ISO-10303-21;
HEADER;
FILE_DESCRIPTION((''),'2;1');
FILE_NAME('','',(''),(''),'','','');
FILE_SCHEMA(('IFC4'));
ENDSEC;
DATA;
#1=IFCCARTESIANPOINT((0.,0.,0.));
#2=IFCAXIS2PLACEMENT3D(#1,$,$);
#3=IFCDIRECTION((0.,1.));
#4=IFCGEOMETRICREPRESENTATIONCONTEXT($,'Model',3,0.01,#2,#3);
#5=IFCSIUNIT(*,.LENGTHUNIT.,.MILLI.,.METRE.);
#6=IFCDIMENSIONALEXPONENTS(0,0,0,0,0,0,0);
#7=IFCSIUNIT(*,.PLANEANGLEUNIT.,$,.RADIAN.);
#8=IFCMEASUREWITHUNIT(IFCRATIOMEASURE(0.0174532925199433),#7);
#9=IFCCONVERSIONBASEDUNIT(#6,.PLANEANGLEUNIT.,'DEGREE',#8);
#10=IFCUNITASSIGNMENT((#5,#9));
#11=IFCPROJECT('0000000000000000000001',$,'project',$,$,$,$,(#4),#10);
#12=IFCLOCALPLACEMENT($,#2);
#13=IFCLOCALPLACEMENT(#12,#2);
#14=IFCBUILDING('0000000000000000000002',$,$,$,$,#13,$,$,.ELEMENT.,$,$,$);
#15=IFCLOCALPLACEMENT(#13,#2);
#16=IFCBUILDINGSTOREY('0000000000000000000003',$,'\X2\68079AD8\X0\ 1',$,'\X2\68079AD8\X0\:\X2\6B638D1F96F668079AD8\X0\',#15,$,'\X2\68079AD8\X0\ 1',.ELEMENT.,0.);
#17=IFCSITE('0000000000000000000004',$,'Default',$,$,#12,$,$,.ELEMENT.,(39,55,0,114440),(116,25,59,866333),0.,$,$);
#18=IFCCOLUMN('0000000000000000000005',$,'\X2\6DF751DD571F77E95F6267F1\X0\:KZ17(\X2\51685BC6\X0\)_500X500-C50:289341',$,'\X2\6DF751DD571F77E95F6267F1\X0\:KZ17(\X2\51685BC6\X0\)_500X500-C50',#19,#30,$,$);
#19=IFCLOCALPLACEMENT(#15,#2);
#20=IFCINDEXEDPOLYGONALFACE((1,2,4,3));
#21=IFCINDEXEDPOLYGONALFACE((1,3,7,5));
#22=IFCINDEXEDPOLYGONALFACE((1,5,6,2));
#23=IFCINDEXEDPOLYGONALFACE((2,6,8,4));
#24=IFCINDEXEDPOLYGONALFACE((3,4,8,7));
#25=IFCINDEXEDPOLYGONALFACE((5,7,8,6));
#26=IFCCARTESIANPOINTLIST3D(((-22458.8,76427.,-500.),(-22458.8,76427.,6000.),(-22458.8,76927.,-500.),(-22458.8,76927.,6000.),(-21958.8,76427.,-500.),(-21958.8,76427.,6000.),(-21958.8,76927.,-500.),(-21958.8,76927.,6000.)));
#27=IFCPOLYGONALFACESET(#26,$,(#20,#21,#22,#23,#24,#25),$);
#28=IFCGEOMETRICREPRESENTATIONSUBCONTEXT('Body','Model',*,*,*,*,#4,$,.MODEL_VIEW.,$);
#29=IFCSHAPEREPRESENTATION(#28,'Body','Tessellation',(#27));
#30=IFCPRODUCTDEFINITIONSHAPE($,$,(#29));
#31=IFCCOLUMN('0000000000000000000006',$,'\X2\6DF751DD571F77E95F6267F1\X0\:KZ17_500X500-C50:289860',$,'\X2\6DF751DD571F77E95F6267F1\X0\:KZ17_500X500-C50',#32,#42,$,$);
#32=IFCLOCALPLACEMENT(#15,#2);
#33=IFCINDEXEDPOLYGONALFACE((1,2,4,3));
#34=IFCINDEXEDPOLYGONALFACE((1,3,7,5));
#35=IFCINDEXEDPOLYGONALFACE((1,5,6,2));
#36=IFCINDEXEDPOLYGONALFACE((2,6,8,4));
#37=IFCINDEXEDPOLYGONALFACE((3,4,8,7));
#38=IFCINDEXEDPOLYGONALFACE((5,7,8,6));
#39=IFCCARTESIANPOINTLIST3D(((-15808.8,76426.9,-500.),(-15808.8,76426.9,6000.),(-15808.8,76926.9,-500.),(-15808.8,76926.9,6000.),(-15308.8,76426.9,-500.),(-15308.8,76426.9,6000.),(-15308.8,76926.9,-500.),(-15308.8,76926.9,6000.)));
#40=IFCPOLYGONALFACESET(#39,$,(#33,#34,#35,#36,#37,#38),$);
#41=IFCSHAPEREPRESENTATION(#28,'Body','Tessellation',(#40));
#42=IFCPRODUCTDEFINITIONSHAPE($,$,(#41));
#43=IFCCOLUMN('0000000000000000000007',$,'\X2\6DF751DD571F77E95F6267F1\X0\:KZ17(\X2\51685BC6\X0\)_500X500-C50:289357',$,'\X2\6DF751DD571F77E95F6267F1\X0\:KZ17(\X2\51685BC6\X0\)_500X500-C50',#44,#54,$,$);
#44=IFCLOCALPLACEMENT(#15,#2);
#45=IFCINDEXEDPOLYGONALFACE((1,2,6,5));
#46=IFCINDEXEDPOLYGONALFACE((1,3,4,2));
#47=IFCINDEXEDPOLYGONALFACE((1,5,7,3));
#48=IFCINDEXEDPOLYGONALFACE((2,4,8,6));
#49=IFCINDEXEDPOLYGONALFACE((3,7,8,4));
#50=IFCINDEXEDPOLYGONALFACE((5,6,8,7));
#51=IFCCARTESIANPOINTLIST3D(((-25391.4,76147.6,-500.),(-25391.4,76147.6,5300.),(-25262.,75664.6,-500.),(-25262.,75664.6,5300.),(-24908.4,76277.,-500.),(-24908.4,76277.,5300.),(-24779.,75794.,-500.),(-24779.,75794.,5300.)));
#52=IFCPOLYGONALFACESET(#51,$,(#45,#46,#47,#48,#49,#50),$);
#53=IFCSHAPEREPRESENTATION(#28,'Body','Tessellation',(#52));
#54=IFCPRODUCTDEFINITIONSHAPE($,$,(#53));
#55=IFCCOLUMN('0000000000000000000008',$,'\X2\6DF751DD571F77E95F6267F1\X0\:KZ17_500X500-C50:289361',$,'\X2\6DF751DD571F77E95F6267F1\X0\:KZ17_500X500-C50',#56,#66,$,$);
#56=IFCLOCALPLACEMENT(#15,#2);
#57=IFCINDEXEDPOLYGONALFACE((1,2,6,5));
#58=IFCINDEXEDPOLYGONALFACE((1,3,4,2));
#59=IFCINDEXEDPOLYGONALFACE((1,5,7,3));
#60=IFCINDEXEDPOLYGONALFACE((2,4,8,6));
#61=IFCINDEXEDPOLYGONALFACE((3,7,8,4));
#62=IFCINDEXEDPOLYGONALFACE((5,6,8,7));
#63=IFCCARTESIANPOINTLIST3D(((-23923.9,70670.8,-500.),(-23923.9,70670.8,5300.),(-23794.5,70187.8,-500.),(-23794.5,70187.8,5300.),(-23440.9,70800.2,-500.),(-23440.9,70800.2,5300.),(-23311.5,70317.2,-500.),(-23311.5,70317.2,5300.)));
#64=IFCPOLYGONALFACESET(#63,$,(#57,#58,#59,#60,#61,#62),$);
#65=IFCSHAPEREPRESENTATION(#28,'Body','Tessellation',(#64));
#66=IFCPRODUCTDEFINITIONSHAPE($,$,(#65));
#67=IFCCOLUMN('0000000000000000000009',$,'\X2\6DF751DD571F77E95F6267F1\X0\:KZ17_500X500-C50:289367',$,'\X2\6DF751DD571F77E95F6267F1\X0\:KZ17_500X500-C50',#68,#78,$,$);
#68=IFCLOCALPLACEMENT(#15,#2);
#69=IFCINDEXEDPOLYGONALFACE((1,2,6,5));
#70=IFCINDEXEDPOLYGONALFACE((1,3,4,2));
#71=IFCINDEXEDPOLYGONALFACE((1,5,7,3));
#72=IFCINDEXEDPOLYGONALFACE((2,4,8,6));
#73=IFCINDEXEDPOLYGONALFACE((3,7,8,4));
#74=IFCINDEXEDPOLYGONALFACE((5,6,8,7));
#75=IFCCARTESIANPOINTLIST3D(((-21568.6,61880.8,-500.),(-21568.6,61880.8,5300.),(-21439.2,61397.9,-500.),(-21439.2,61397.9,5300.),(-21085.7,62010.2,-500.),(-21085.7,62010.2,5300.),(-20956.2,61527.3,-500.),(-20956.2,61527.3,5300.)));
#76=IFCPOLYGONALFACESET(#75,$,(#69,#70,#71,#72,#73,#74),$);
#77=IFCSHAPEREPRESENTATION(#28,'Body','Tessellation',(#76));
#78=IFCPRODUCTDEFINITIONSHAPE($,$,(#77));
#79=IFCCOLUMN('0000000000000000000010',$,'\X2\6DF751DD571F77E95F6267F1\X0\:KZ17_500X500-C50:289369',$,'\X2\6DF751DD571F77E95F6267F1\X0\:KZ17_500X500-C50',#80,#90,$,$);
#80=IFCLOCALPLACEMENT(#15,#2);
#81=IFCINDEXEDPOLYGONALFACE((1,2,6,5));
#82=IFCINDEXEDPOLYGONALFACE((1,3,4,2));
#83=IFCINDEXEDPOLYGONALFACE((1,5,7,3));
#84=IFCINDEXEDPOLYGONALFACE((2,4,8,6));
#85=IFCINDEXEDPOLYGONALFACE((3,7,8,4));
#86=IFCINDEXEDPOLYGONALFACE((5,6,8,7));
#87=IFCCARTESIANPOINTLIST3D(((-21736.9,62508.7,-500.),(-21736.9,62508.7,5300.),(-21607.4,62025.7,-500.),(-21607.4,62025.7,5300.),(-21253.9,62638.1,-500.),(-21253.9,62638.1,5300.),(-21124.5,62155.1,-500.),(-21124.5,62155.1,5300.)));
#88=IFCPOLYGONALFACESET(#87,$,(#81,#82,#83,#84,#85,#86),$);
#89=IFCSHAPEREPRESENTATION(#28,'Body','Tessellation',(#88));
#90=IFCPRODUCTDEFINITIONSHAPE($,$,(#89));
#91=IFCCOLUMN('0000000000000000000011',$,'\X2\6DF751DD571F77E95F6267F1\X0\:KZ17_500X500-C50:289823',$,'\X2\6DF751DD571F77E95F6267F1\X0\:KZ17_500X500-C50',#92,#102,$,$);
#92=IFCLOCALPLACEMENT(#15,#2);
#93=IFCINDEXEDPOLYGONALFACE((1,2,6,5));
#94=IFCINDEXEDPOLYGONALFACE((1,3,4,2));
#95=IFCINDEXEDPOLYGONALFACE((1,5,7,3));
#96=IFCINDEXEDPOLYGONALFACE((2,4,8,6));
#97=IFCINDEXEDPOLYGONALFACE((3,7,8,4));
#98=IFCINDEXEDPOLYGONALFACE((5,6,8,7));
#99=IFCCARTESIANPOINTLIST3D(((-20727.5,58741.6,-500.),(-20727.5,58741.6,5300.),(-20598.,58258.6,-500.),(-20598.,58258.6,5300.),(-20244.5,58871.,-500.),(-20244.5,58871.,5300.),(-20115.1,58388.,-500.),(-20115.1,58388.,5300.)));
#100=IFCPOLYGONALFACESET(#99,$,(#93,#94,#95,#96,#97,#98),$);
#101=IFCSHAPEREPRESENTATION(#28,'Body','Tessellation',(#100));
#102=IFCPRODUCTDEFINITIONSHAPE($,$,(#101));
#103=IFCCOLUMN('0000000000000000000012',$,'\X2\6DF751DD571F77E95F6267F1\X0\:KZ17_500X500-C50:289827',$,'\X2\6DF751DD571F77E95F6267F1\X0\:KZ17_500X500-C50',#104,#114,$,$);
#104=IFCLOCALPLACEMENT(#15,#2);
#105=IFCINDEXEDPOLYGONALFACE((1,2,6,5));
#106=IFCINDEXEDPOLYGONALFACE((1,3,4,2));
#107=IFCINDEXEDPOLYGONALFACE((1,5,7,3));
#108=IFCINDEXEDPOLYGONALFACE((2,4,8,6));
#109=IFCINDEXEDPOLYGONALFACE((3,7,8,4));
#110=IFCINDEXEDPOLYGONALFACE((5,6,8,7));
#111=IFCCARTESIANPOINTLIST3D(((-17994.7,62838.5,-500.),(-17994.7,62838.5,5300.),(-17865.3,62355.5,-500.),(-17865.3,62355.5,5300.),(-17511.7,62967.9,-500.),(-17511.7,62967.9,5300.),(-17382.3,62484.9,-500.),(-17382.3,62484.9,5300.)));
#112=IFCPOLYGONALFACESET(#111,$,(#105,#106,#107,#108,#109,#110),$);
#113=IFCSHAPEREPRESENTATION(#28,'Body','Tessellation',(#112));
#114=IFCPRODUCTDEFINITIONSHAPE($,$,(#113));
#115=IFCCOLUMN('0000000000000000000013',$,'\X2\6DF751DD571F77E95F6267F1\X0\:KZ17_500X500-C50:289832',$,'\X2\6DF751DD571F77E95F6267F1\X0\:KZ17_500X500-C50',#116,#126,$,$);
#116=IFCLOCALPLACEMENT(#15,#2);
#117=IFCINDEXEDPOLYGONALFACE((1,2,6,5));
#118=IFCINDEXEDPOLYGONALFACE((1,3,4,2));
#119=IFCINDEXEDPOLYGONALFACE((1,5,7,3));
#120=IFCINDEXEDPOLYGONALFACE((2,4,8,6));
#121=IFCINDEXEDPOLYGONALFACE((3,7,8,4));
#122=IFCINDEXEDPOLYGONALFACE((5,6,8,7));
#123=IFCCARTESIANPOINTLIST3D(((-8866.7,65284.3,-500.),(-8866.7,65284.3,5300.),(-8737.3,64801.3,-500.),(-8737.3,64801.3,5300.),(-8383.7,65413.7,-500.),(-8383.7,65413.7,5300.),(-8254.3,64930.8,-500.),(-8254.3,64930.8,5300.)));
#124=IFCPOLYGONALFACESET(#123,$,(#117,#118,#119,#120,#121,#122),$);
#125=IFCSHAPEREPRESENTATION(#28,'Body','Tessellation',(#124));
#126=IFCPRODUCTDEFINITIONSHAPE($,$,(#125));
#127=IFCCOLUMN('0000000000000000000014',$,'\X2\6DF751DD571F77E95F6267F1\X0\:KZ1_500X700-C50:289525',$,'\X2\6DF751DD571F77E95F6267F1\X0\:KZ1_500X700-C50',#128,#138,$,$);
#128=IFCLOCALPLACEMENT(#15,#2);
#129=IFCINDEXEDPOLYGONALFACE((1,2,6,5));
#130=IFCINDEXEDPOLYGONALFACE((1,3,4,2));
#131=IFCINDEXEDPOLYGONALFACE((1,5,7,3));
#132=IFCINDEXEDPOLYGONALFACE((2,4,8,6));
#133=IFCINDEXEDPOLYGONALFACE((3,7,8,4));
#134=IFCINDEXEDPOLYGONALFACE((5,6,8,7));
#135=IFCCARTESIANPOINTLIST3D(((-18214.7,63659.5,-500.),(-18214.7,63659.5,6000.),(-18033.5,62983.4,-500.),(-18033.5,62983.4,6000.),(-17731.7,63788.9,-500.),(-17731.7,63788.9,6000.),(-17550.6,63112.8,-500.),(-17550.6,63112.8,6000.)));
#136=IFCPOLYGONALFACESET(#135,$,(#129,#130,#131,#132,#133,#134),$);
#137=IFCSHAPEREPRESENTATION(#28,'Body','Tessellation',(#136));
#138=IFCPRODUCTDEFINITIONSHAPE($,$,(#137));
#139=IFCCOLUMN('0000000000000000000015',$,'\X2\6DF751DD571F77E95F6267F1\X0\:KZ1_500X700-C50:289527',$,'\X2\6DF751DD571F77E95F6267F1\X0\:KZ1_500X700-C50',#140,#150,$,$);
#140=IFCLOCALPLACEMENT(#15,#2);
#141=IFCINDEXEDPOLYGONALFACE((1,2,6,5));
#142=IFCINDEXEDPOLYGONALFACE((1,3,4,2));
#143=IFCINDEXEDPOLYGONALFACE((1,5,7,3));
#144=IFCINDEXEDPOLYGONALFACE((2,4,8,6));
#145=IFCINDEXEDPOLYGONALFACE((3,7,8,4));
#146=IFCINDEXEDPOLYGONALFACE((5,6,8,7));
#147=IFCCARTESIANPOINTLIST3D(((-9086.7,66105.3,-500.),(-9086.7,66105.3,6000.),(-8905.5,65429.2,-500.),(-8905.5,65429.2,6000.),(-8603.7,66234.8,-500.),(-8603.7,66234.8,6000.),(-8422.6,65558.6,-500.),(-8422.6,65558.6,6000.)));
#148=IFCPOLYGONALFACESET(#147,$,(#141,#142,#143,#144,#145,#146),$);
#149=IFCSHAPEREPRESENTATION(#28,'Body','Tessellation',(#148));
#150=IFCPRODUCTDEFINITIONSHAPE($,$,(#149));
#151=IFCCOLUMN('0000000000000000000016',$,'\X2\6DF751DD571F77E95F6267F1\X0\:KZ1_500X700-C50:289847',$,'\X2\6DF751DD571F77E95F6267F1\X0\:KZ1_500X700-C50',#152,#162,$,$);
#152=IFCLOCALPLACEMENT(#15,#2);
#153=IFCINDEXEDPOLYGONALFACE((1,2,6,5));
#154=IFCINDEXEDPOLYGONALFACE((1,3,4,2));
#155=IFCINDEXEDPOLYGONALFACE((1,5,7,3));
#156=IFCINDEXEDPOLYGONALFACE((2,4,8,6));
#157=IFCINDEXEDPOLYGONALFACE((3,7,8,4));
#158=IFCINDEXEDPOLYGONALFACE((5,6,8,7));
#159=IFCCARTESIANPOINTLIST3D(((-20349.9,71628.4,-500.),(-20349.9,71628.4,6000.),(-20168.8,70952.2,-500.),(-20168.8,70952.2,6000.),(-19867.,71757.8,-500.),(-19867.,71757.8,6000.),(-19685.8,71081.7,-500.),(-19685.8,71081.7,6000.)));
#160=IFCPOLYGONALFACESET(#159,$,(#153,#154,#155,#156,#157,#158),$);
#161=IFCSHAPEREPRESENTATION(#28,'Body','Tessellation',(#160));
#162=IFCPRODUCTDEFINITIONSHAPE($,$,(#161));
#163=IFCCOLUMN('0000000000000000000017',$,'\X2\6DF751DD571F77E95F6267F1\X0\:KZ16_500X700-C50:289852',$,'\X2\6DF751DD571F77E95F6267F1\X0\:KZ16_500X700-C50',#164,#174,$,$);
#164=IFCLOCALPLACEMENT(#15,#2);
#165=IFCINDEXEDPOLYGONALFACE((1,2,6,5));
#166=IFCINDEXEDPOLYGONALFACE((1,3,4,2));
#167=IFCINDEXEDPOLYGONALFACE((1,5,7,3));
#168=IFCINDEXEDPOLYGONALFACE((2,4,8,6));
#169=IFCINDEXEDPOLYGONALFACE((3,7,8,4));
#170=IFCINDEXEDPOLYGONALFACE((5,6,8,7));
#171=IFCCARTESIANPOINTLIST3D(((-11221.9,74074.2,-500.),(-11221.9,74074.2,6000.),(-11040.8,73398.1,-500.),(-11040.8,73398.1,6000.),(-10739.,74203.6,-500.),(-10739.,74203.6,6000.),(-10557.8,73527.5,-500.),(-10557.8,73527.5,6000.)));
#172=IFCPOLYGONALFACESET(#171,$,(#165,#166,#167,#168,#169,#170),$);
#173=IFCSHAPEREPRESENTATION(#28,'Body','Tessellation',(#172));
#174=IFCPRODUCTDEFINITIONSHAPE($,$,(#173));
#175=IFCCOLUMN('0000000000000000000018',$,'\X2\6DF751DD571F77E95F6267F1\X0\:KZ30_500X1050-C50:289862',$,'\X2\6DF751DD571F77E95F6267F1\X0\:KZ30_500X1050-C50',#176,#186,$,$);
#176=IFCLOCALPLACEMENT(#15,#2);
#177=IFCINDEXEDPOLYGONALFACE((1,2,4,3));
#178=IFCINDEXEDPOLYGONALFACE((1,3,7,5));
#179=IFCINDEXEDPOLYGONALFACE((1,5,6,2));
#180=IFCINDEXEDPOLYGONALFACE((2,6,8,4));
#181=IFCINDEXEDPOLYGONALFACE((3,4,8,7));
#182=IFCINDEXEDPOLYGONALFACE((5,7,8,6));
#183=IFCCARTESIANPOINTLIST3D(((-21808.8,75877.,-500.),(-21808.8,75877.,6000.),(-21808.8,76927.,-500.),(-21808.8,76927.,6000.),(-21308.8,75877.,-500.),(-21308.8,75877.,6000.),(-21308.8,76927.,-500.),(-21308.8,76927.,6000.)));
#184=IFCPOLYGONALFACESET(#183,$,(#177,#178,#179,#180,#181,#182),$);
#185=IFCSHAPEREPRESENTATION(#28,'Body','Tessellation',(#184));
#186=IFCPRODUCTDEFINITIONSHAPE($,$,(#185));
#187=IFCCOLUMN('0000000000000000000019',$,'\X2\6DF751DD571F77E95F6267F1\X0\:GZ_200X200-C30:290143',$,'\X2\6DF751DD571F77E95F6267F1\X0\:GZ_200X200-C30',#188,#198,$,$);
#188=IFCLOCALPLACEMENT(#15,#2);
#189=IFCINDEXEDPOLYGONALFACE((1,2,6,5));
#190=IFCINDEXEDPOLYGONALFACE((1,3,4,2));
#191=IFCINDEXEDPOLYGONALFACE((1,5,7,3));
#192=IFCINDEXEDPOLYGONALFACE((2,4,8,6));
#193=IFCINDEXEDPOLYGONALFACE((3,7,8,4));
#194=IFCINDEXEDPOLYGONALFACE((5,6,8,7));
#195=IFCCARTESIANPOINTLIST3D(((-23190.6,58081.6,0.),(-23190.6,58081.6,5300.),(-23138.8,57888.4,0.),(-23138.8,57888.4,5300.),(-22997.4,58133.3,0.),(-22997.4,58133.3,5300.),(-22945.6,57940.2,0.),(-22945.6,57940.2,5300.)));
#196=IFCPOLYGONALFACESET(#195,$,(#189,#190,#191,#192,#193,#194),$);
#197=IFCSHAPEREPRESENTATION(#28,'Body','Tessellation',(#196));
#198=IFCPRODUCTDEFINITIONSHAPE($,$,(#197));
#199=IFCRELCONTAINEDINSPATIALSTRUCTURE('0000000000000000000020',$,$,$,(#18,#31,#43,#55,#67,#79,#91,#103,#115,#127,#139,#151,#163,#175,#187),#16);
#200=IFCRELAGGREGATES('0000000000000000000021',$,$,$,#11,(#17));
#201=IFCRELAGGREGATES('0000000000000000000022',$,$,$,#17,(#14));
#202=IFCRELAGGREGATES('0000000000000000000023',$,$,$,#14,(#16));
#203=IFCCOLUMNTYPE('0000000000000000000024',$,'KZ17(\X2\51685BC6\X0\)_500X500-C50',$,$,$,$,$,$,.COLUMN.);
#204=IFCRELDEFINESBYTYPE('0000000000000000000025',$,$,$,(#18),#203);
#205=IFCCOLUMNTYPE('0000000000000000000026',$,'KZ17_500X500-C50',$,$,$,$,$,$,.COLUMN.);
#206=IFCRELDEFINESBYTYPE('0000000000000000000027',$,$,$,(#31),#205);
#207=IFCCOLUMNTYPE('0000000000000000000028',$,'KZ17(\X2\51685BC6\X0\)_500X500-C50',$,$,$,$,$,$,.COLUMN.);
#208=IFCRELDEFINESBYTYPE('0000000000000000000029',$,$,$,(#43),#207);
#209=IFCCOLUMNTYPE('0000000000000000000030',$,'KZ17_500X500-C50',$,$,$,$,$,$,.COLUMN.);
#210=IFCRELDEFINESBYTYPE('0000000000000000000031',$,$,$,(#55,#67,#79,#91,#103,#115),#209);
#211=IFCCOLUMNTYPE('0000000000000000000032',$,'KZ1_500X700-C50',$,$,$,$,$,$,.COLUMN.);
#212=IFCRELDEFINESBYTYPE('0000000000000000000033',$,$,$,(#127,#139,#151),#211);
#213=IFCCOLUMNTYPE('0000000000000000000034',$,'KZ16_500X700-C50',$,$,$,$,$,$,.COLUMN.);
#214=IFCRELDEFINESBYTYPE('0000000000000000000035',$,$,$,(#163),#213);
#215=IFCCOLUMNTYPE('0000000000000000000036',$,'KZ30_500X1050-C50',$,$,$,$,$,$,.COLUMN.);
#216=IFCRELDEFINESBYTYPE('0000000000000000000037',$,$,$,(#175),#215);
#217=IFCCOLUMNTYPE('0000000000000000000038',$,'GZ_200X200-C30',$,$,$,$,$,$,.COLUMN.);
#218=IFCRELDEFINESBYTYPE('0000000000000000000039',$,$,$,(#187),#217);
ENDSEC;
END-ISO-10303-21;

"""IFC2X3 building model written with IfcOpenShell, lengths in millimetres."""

from ifc_helpers import new_model, entity, si_unit, converted_unit, direction, frame, origin, origin_2d_with_axis, place, context, subcontext, project, spatial, rectangle, extrude, source, transform, mapped, type_object, type_shapes, element, save


model = new_model("IFC2X3")

# Units and contexts
model_context = context("Model", 3, precision=0.01, world=origin(), true_north=direction((0.0, 1.0)))
body_context = subcontext(model_context, "Body", "Model", "MODEL_VIEW")
ifc_project = project(units=[si_unit("LENGTHUNIT", "METRE", prefix="MILLI"), converted_unit("PLANEANGLEUNIT", "DEGREE", entity("IfcRatioMeasure", 0.0174532925199433), si_unit("PLANEANGLEUNIT", "RADIAN"), dimensions=[0, 0, 0, 0, 0, 0, 0])], contexts=[model_context])

# Site, building, storey
site_placement = place(None, origin())
site = spatial("IfcSite", under=ifc_project, at=site_placement, Name="Default", CompositionType="ELEMENT", RefLatitude=(39, 55, 0, 114440), RefLongitude=(116, 25, 59, 866333), RefElevation=0.0)
building_placement = place(site_placement, origin())
building = spatial("IfcBuilding", under=site, at=building_placement, CompositionType="ELEMENT")
storey_placement = place(building_placement, origin())
storey = spatial("IfcBuildingStorey", under=building, at=storey_placement, Name="标高 1", ObjectType="标高:正负零标高", LongName="标高 1", CompositionType="ELEMENT", Elevation=0.0)

# Columns
column_type_1 = type_object("IfcColumnType", Name="KZ17(全密)_500X500-C50", PredefinedType="COLUMN")
shared_shape_1 = source(origin(), body_context, "Body", "SweptSolid", [
    extrude(rectangle(XDim=500.0, YDim=500.0, at=origin_2d_with_axis()), frame((0.0, 0.0, -500.0), z_axis=(0.0, 0.0, 1.0), x_axis=(0.0, -1.0, 0.0)), (0.0, 0.0, 1.0), 6500.0),
])
type_shapes(column_type_1, [shared_shape_1])
column_1_placement = place(building_placement, frame((-22208.8, 76677.0, 0.0)))
element("IfcColumn", 1, at=column_1_placement, inside=storey, type_object=column_type_1, Name="混凝土矩形柱:KZ17(全密)_500X500-C50:289341", ObjectType="混凝土矩形柱:KZ17(全密)_500X500-C50", context=body_context, shape_type="MappedRepresentation", body=[
    mapped(shared_shape_1, transform((0.0, 0.0, 0.0), scale=1.0)),
])
column_type_2 = type_object("IfcColumnType", Name="KZ17_500X500-C50", PredefinedType="COLUMN")
shared_shape_2 = source(origin(), body_context, "Body", "SweptSolid", [
    extrude(rectangle(XDim=500.0, YDim=500.0, at=origin_2d_with_axis()), frame((0.0, 0.0, -500.0), z_axis=(0.0, 0.0, 1.0), x_axis=(0.0, -1.0, 0.0)), (0.0, 0.0, 1.0), 6500.0),
])
type_shapes(column_type_2, [shared_shape_2])
column_2_placement = place(building_placement, frame((-15558.8, 76676.9, 0.0)))
element("IfcColumn", 2, at=column_2_placement, inside=storey, type_object=column_type_2, Name="混凝土矩形柱:KZ17_500X500-C50:289860", ObjectType="混凝土矩形柱:KZ17_500X500-C50", context=body_context, shape_type="MappedRepresentation", body=[
    mapped(shared_shape_2, transform((0.0, 0.0, 0.0), scale=1.0)),
])
column_type_3 = type_object("IfcColumnType", Name="KZ17(全密)_500X500-C50", PredefinedType="COLUMN")
shared_shape_3 = source(origin(), body_context, "Body", "SweptSolid", [
    extrude(rectangle(XDim=500.0, YDim=500.0, at=origin_2d_with_axis()), frame((0.0, 0.0, -500.0), z_axis=(0.0, 0.0, 1.0), x_axis=(0.0, -1.0, 0.0)), (0.0, 0.0, 1.0), 5800.0),
])
type_shapes(column_type_3, [shared_shape_3])
column_3_placement = place(building_placement, frame((-25085.2, 75970.8, 0.0), z_axis=(0.0, 0.0, 1.0), x_axis=(0.258819, -0.965926, 0.0)))
element("IfcColumn", 3, at=column_3_placement, inside=storey, type_object=column_type_3, Name="混凝土矩形柱:KZ17(全密)_500X500-C50:289357", ObjectType="混凝土矩形柱:KZ17(全密)_500X500-C50", context=body_context, shape_type="MappedRepresentation", body=[
    mapped(shared_shape_3, transform((0.0, 0.0, 0.0), scale=1.0)),
])
column_type_4 = type_object("IfcColumnType", Name="KZ17_500X500-C50", PredefinedType="COLUMN")
shared_shape_4 = source(origin(), body_context, "Body", "SweptSolid", [
    extrude(rectangle(XDim=500.0, YDim=500.0, at=origin_2d_with_axis()), frame((0.0, 0.0, -500.0), z_axis=(0.0, 0.0, 1.0), x_axis=(0.0, -1.0, 0.0)), (0.0, 0.0, 1.0), 5800.0),
])
type_shapes(column_type_4, [shared_shape_4])
for number, where, z_axis, x_axis, name in (
    (4, (-23617.7, 70494.0, 0.0), (0.0, 0.0, 1.0), (0.258819, -0.965926, 0.0), "混凝土矩形柱:KZ17_500X500-C50:289361"),
    (5, (-21262.4, 61704.1, 0.0), (0.0, 0.0, 1.0), (0.258819, -0.965926, 0.0), "混凝土矩形柱:KZ17_500X500-C50:289367"),
    (6, (-21430.7, 62331.9, 0.0), (0.0, 0.0, 1.0), (0.258819, -0.965926, 0.0), "混凝土矩形柱:KZ17_500X500-C50:289369"),
    (7, (-20421.3, 58564.8, 0.0), (0.0, 0.0, 1.0), (0.258819, -0.965926, 0.0), "混凝土矩形柱:KZ17_500X500-C50:289823"),
    (8, (-17688.5, 62661.7, 0.0), (0.0, 0.0, 1.0), (0.258819, -0.965926, 0.0), "混凝土矩形柱:KZ17_500X500-C50:289827"),
    (9, (-8560.5, 65107.5, 0.0), (0.0, 0.0, 1.0), (0.258819, -0.965926, 0.0), "混凝土矩形柱:KZ17_500X500-C50:289832"),
):
    element("IfcColumn", number, at=place(building_placement, frame(where, z_axis=z_axis, x_axis=x_axis)), inside=storey, type_object=column_type_4, Name=name, ObjectType="混凝土矩形柱:KZ17_500X500-C50", context=body_context, shape_type="MappedRepresentation", body=[
        mapped(shared_shape_4, transform((0.0, 0.0, 0.0), scale=1.0)),
    ])
column_type_5 = type_object("IfcColumnType", Name="KZ1_500X700-C50", PredefinedType="COLUMN")
shared_shape_5 = source(origin(), body_context, "Body", "SweptSolid", [
    extrude(rectangle(XDim=700.0, YDim=500.0, at=origin_2d_with_axis()), frame((0.0, 0.0, -500.0), z_axis=(0.0, 0.0, 1.0), x_axis=(0.0, -1.0, 0.0)), (0.0, 0.0, 1.0), 6500.0),
])
type_shapes(column_type_5, [shared_shape_5])
for number, where, z_axis, x_axis, name in (
    (10, (-17882.6, 63386.1, 0.0), (0.0, 0.0, 1.0), (0.965926, 0.258819, 0.0), "混凝土矩形柱:KZ1_500X700-C50:289525"),
    (11, (-8754.6, 65832.0, 0.0), (0.0, 0.0, 1.0), (0.965926, 0.258819, 0.0), "混凝土矩形柱:KZ1_500X700-C50:289527"),
    (12, (-20017.9, 71355.0, 0.0), (0.0, 0.0, 1.0), (0.965926, 0.258819, 0.0), "混凝土矩形柱:KZ1_500X700-C50:289847"),
):
    element("IfcColumn", number, at=place(building_placement, frame(where, z_axis=z_axis, x_axis=x_axis)), inside=storey, type_object=column_type_5, Name=name, ObjectType="混凝土矩形柱:KZ1_500X700-C50", context=body_context, shape_type="MappedRepresentation", body=[
        mapped(shared_shape_5, transform((0.0, 0.0, 0.0), scale=1.0)),
    ])
column_type_6 = type_object("IfcColumnType", Name="KZ16_500X700-C50", PredefinedType="COLUMN")
shared_shape_6 = source(origin(), body_context, "Body", "SweptSolid", [
    extrude(rectangle(XDim=700.0, YDim=500.0, at=origin_2d_with_axis()), frame((0.0, 0.0, -500.0), z_axis=(0.0, 0.0, 1.0), x_axis=(0.0, -1.0, 0.0)), (0.0, 0.0, 1.0), 6500.0),
])
type_shapes(column_type_6, [shared_shape_6])
column_4_placement = place(building_placement, frame((-10889.9, 73800.9, 0.0), z_axis=(0.0, 0.0, 1.0), x_axis=(0.965926, 0.258819, 0.0)))
element("IfcColumn", 13, at=column_4_placement, inside=storey, type_object=column_type_6, Name="混凝土矩形柱:KZ16_500X700-C50:289852", ObjectType="混凝土矩形柱:KZ16_500X700-C50", context=body_context, shape_type="MappedRepresentation", body=[
    mapped(shared_shape_6, transform((0.0, 0.0, 0.0), scale=1.0)),
])
column_type_7 = type_object("IfcColumnType", Name="KZ30_500X1050-C50", PredefinedType="COLUMN")
shared_shape_7 = source(origin(), body_context, "Body", "SweptSolid", [
    extrude(rectangle(XDim=1050.0, YDim=500.0, at=origin_2d_with_axis()), frame((0.0, 0.0, -500.0), z_axis=(0.0, 0.0, 1.0), x_axis=(0.0, -1.0, 0.0)), (0.0, 0.0, 1.0), 6500.0),
])
type_shapes(column_type_7, [shared_shape_7])
column_5_placement = place(building_placement, frame((-21558.8, 76402.0, 0.0)))
element("IfcColumn", 14, at=column_5_placement, inside=storey, type_object=column_type_7, Name="混凝土矩形柱:KZ30_500X1050-C50:289862", ObjectType="混凝土矩形柱:KZ30_500X1050-C50", context=body_context, shape_type="MappedRepresentation", body=[
    mapped(shared_shape_7, transform((0.0, 0.0, 0.0), scale=1.0)),
])
column_type_8 = type_object("IfcColumnType", Name="GZ_200X200-C30", PredefinedType="COLUMN")
shared_shape_8 = source(origin(), body_context, "Body", "SweptSolid", [
    extrude(rectangle(XDim=200.0, YDim=200.0, at=origin_2d_with_axis()), frame((0.0, 0.0, 0.0), z_axis=(0.0, 0.0, 1.0), x_axis=(0.0, -1.0, 0.0)), (0.0, 0.0, 1.0), 5300.0),
])
type_shapes(column_type_8, [shared_shape_8])
column_6_placement = place(building_placement, frame((-23068.1, 58010.9, 0.0), z_axis=(0.0, 0.0, 1.0), x_axis=(0.965926, 0.258819, 0.0)))
element("IfcColumn", 15, at=column_6_placement, inside=storey, type_object=column_type_8, Name="混凝土矩形柱:GZ_200X200-C30:290143", ObjectType="混凝土矩形柱:GZ_200X200-C30", context=body_context, shape_type="MappedRepresentation", body=[
    mapped(shared_shape_8, transform((0.0, 0.0, 0.0), scale=1.0)),
])

save(model, "model.ifc")
